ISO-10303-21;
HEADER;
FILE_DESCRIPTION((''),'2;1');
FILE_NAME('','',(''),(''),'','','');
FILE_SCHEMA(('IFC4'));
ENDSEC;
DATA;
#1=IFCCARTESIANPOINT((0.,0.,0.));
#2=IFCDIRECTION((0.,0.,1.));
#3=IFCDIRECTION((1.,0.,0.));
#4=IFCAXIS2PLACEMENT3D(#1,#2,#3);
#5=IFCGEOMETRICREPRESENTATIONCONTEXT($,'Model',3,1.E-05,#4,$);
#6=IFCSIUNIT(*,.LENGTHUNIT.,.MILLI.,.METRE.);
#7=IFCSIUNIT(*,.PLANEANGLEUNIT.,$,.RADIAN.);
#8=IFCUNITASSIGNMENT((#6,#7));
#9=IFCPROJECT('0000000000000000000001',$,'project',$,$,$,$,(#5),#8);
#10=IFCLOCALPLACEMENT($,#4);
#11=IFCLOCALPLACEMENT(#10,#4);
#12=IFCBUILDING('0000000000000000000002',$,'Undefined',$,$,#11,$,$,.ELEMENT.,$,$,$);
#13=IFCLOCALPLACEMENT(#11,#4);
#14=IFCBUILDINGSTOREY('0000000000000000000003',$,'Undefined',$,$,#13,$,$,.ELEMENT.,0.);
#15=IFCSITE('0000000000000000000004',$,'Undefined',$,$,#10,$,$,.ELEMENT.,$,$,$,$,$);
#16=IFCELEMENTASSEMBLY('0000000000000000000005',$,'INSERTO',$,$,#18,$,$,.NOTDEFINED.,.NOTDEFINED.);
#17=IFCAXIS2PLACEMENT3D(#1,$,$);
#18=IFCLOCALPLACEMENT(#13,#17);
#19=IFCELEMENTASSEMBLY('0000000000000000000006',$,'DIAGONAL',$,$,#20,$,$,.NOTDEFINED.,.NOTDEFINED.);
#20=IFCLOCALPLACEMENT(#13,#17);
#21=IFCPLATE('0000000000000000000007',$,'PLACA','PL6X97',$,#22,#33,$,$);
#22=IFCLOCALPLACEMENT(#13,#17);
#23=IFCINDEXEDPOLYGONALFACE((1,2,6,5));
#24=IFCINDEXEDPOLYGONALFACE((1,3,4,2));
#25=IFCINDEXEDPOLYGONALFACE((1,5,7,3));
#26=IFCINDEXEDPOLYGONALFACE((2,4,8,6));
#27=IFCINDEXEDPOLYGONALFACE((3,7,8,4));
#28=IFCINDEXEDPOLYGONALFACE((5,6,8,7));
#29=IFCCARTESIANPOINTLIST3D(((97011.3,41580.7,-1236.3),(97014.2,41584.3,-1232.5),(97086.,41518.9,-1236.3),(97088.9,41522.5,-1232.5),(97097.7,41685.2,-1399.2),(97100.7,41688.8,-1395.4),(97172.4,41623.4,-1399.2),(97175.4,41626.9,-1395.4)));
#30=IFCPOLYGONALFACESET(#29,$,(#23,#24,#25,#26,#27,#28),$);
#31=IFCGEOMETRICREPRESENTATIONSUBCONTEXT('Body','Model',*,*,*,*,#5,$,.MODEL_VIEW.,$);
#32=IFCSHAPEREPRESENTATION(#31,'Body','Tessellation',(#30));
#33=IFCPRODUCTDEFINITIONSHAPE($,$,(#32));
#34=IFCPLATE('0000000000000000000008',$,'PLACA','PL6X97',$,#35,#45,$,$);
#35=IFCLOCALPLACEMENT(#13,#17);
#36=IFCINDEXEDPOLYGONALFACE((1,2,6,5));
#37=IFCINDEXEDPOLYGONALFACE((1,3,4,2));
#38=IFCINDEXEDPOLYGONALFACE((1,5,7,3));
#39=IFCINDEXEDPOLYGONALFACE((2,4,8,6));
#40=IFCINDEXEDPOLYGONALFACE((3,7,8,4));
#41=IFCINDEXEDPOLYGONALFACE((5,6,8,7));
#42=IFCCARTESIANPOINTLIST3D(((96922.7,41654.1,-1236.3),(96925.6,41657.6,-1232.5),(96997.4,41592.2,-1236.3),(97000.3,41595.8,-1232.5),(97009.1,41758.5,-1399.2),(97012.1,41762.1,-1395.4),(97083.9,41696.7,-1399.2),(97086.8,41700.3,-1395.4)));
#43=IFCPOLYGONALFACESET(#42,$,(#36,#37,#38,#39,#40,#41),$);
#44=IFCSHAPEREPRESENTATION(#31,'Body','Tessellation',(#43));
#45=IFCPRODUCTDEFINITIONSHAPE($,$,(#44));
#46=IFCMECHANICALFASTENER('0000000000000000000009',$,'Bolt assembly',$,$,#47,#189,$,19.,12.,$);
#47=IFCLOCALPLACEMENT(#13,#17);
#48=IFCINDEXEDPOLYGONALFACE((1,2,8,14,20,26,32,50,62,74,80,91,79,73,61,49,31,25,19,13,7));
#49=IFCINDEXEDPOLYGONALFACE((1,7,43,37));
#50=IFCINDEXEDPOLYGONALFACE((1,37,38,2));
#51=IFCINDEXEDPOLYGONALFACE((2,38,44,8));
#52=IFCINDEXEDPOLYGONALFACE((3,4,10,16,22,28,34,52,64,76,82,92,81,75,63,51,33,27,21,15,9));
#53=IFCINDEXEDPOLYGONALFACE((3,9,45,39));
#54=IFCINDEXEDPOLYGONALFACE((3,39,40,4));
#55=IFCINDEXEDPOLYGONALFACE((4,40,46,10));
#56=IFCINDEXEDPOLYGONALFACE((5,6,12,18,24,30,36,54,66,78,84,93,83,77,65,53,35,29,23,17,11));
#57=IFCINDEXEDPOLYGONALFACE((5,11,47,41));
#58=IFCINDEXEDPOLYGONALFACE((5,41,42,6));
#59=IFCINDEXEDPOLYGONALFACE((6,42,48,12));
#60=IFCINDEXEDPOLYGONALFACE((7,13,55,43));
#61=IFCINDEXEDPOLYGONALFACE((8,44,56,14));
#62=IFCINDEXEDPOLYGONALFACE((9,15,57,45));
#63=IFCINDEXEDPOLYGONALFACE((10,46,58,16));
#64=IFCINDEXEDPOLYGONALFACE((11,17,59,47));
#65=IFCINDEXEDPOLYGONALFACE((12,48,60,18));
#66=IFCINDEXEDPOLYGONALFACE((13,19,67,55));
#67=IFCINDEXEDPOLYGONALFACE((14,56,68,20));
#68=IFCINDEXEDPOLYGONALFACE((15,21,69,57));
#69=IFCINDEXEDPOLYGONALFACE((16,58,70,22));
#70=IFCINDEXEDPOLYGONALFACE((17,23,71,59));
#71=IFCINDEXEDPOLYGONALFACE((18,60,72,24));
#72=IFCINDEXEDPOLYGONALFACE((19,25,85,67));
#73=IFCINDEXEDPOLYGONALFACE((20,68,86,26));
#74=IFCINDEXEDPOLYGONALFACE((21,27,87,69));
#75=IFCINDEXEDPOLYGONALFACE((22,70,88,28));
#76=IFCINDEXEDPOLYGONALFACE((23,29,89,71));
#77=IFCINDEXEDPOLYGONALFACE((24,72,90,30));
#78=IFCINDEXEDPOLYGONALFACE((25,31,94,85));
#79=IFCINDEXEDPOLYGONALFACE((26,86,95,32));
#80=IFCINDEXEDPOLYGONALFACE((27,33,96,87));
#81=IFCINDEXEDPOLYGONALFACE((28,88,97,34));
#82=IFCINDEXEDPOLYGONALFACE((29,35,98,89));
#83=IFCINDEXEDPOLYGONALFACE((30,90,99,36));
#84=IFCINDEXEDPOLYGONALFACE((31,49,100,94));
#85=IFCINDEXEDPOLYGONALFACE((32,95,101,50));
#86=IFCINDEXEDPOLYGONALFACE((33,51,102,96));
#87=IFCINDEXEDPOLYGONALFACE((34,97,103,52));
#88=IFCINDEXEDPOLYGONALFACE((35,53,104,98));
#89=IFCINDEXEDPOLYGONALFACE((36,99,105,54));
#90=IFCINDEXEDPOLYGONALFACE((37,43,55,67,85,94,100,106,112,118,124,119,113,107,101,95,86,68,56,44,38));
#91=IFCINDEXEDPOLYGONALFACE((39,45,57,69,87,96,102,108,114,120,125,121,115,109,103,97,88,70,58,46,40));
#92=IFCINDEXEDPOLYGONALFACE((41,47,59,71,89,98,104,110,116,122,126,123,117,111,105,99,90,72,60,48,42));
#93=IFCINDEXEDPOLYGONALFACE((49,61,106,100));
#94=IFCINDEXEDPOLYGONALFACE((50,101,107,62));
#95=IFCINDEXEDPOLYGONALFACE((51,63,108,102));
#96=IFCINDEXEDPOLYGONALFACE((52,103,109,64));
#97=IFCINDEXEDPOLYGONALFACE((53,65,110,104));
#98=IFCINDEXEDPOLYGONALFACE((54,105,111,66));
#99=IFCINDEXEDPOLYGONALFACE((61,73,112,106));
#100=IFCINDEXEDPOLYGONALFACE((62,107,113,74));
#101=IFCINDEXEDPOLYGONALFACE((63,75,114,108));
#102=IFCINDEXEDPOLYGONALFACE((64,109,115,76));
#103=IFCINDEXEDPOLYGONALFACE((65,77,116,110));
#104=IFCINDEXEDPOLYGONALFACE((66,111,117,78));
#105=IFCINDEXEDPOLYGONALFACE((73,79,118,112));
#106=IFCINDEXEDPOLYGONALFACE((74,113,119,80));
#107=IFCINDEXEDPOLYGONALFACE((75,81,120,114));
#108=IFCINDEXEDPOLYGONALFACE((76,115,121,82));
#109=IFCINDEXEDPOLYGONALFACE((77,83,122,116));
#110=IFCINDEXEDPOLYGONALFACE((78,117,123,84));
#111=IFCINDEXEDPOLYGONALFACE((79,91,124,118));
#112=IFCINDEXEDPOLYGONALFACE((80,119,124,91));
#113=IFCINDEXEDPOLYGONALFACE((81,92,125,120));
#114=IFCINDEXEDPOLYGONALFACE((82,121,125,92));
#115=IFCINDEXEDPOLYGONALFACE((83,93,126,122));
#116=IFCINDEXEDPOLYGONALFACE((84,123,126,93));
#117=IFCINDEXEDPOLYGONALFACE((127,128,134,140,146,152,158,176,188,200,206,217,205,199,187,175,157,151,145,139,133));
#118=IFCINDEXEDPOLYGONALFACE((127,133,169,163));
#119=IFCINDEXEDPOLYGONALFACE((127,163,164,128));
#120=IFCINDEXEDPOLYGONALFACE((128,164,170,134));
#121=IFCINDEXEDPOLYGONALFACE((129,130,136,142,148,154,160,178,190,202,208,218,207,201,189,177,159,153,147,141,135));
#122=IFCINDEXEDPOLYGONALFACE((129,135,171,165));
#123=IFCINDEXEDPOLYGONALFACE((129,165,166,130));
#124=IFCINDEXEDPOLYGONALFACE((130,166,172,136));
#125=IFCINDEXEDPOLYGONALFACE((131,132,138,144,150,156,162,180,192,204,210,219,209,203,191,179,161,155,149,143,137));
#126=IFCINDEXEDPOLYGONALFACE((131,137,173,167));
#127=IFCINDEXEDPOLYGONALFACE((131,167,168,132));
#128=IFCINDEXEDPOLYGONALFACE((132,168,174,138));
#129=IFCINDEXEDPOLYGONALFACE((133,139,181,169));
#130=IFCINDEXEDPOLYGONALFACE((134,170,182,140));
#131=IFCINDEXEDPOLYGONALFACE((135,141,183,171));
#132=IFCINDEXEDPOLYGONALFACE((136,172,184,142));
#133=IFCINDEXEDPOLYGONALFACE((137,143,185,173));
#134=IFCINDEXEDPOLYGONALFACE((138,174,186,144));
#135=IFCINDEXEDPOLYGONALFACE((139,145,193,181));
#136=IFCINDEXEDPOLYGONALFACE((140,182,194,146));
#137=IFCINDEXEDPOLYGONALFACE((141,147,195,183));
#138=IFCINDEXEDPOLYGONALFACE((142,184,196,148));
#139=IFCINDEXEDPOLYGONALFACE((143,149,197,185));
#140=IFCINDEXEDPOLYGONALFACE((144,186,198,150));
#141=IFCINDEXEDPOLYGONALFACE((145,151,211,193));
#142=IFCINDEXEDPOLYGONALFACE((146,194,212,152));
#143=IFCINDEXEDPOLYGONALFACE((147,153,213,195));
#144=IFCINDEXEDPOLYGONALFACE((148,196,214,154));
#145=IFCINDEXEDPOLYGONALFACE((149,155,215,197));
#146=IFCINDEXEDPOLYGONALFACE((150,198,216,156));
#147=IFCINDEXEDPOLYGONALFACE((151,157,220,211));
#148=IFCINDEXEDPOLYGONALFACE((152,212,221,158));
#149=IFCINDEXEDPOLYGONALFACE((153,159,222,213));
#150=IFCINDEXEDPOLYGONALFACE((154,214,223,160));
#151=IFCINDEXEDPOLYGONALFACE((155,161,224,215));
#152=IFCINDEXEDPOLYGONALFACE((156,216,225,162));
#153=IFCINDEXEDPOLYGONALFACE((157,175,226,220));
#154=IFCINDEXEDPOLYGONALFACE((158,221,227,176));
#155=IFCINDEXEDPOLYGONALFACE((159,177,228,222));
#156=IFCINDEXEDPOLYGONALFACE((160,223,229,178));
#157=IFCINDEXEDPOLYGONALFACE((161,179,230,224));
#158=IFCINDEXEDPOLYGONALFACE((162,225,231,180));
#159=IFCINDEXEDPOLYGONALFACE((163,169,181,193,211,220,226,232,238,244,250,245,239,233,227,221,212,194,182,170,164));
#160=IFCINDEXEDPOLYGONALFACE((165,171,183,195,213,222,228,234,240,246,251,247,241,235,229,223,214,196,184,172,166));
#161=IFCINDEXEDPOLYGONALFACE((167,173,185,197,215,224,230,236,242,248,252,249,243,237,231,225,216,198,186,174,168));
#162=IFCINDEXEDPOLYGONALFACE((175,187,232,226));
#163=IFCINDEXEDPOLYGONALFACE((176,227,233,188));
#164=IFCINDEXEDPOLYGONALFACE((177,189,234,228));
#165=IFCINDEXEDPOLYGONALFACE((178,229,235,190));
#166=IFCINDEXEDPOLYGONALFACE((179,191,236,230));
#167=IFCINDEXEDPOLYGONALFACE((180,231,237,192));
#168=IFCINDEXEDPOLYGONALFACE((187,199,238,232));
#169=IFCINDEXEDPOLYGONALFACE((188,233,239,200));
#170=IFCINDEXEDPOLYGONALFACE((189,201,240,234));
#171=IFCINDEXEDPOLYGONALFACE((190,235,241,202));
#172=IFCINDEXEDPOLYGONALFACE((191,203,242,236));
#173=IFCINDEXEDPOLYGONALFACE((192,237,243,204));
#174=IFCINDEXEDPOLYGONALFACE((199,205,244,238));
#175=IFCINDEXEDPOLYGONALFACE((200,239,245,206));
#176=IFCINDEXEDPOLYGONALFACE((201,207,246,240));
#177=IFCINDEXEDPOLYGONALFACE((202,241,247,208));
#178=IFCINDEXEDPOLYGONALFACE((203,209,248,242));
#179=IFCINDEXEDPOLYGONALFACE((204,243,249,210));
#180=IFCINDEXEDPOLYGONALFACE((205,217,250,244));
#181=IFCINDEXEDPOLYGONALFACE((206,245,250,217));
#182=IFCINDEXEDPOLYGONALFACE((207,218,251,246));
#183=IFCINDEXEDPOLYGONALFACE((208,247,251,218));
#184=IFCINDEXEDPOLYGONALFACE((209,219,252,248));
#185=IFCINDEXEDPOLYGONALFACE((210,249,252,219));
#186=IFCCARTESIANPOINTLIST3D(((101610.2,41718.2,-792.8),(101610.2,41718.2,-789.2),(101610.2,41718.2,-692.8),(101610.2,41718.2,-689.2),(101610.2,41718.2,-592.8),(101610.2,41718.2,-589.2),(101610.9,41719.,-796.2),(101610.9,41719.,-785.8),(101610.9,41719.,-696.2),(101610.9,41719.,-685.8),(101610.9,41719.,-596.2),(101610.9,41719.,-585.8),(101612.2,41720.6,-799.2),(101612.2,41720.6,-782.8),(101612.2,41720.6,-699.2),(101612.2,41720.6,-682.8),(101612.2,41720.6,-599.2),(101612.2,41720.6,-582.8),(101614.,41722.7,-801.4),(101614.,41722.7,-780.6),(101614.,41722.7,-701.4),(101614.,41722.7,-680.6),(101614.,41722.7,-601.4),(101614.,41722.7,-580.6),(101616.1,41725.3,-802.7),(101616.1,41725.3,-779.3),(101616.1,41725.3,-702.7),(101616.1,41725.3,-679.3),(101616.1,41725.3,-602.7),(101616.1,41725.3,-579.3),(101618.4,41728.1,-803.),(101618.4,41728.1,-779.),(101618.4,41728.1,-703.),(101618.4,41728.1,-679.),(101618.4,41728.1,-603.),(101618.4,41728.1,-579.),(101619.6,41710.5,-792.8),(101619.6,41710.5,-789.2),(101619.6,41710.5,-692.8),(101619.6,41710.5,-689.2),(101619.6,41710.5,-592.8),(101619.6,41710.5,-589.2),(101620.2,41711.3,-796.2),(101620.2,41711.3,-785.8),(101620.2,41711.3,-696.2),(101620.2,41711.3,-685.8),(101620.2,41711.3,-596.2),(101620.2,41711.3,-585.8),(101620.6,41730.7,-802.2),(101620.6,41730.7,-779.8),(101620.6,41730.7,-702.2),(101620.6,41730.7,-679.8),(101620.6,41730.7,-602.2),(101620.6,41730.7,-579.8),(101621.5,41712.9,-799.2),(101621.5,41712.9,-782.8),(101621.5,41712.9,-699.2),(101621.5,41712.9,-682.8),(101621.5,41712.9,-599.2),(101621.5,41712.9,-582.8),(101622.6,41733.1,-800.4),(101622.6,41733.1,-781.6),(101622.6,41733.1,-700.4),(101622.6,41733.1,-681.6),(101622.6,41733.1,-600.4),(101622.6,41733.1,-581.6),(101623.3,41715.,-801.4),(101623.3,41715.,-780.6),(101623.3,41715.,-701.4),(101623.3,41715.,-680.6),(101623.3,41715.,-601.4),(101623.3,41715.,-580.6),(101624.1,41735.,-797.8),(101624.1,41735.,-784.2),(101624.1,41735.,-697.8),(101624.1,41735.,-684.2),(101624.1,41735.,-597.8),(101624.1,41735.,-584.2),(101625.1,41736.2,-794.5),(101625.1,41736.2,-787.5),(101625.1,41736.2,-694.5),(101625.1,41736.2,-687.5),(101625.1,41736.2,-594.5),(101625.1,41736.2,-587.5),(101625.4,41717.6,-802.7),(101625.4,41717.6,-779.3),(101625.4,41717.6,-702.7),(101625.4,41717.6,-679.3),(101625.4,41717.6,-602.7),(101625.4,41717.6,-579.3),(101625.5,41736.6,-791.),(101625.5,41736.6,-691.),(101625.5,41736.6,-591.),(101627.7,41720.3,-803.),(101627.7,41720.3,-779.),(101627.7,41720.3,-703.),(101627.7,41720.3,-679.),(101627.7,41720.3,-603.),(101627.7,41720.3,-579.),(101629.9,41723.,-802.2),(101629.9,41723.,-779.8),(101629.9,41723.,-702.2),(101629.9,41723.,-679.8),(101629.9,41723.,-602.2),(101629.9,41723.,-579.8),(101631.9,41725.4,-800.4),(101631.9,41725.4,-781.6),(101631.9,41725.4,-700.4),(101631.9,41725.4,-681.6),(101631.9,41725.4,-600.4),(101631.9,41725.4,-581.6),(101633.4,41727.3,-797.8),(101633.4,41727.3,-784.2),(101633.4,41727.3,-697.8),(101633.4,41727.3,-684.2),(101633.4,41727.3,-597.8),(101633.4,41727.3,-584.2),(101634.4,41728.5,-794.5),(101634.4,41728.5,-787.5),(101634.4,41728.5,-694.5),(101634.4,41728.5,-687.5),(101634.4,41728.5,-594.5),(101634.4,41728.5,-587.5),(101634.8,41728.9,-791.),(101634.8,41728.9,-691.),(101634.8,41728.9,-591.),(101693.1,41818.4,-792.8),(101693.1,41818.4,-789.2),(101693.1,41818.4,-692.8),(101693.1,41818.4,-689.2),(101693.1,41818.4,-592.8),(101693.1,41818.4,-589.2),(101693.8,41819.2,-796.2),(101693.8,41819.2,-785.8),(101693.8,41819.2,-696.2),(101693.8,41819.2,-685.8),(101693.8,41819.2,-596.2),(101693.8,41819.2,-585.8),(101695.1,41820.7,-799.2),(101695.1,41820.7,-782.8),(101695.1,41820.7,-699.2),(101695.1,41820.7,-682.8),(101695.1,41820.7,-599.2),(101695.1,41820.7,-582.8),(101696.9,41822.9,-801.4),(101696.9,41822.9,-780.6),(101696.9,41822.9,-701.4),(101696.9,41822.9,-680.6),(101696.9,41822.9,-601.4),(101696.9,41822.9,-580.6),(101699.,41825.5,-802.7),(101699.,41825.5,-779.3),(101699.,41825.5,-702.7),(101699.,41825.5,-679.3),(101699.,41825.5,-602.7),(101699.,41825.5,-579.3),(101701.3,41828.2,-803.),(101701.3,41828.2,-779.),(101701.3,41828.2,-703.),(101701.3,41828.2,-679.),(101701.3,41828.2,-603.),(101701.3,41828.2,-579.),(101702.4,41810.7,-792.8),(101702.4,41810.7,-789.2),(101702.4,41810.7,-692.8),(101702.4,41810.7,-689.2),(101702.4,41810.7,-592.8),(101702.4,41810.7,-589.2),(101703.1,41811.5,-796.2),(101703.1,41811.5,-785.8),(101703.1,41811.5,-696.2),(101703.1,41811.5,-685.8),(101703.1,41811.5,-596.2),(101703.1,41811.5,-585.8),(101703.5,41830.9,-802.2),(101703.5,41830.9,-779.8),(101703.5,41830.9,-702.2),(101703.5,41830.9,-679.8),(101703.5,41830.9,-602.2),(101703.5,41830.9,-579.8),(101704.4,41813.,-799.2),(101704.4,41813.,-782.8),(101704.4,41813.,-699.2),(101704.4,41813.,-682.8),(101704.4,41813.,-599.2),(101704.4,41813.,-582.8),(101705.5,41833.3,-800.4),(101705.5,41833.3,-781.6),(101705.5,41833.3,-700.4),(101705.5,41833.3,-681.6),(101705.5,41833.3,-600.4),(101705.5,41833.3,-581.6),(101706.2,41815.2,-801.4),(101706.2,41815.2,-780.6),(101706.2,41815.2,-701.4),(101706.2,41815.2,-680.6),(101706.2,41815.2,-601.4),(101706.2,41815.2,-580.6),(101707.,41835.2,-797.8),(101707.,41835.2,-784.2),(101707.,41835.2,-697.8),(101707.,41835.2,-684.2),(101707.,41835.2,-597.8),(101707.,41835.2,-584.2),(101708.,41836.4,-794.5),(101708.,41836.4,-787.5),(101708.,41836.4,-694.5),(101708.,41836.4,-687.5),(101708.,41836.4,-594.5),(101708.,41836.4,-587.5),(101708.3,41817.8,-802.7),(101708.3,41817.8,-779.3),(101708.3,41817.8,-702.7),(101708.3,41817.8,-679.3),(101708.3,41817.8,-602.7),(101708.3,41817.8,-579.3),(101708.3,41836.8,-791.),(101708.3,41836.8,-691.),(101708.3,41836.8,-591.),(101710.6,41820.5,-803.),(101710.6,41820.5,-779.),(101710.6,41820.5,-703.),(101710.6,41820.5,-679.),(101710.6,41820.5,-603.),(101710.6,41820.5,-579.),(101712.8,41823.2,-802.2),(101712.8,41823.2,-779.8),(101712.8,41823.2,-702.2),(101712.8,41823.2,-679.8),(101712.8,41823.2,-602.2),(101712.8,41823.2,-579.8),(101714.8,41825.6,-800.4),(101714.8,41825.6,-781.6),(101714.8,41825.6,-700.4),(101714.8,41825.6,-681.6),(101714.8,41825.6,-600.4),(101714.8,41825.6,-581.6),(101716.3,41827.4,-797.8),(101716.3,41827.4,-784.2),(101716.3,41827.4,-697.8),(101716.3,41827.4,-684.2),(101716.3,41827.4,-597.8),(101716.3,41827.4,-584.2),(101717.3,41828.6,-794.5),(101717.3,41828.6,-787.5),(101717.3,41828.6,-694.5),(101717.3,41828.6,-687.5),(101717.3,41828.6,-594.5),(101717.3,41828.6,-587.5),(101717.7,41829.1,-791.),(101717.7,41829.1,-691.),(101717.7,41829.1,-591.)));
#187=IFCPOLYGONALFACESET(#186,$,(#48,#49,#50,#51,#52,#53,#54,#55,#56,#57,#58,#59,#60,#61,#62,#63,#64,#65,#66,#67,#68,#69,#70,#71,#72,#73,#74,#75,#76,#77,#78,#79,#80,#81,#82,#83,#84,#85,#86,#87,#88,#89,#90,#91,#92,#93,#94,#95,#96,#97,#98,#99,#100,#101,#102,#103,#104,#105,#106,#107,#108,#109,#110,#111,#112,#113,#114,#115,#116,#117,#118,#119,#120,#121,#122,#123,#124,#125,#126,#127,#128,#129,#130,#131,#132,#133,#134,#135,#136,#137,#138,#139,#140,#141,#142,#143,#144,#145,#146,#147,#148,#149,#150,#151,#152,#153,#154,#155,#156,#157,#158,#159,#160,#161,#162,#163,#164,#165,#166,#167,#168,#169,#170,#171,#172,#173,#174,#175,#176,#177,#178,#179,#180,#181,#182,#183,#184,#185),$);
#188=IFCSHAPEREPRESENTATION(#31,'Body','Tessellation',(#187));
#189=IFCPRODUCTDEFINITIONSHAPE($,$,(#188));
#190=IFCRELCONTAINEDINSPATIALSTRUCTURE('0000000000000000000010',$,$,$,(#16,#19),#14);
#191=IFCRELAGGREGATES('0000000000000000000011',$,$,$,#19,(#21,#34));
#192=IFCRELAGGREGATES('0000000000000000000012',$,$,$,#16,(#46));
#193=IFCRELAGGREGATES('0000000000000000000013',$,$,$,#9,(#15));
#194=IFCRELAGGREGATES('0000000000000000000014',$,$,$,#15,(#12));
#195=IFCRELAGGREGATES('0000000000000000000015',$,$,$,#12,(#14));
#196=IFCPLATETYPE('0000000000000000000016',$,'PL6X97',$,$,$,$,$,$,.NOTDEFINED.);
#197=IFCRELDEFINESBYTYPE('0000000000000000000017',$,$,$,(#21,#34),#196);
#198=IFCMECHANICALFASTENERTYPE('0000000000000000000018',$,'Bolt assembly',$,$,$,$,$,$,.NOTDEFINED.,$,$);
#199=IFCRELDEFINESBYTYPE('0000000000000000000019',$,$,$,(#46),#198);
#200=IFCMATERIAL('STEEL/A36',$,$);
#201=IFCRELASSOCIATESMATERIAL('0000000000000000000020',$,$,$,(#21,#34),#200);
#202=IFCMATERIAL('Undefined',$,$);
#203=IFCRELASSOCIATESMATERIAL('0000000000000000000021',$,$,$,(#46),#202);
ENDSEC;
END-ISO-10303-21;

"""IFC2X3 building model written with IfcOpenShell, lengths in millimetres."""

from ifc_helpers import new_model, si_unit, frame, origin_with_axes, origin_2d_with_axis, place, context, subcontext, project, spatial, polyline, circle, outline, extrude, source, transform, mapped, material, type_object, element, aggregate, save


model = new_model("IFC2X3")

# Units and contexts
model_context = context("Model", 3, precision=1e-05, world=origin_with_axes())
body_context = subcontext(model_context, "Body", "Model", "MODEL_VIEW")
ifc_project = project(units=[si_unit("LENGTHUNIT", "METRE", prefix="MILLI"), si_unit("PLANEANGLEUNIT", "RADIAN")], contexts=[model_context])

# Site, building, storey
site_placement = place(None, origin_with_axes())
site = spatial("IfcSite", under=ifc_project, at=site_placement, Name="Undefined", CompositionType="ELEMENT")
building_placement = place(site_placement, origin_with_axes())
building = spatial("IfcBuilding", under=site, at=building_placement, Name="Undefined", CompositionType="ELEMENT")
storey_placement = place(building_placement, origin_with_axes())
storey = spatial("IfcBuildingStorey", under=building, at=storey_placement, Name="Undefined", CompositionType="ELEMENT", Elevation=0.0)

# Element assembly
assembly_1_placement = place(storey_placement, origin_with_axes())
assembly_1 = element("IfcElementAssembly", 1, at=assembly_1_placement, inside=storey, Name="INSERTO", AssemblyPlace="NOTDEFINED", PredefinedType="NOTDEFINED")
ifc_material_1 = material(Name="STEEL/A36")

# Element assembly, plates
assembly_2_placement = place(storey_placement, origin_with_axes())
assembly_2 = element("IfcElementAssembly", 2, at=assembly_2_placement, inside=storey, Name="DIAGONAL", AssemblyPlace="NOTDEFINED", PredefinedType="NOTDEFINED")
plate_type_1 = type_object("IfcPlateType", Name="PL6X97", PredefinedType="NOTDEFINED")
plate_1_placement = place(assembly_2_placement, frame((97087.5, 41520.7, -1234.4), z_axis=(-0.490051, -0.592157, -0.639687), x_axis=(-0.770401, 0.63756, 0.0)))
plate_1 = element("IfcPlate", 3, at=plate_1_placement, type_object=plate_type_1, material=ifc_material_1, Name="PLACA", Description="PL6X97", context=body_context, shape_type="SweptSolid", body=[
    extrude(outline(polyline([(0.0, 0.0), (97.0, 0.0), (97.0, 212.0), (0.0, 212.0), (0.0, 0.0)])), frame((0.0, 0.0, -3.0), z_axis=(0.0, 0.0, 1.0), x_axis=(1.0, 0.0, 0.0)), (0.0, 0.0, 1.0), 6.0),
])
plate_2_placement = place(assembly_2_placement, frame((96998.9, 41594.0, -1234.4), z_axis=(-0.490051, -0.592157, -0.639687), x_axis=(-0.770401, 0.63756, 0.0)))
plate_2 = element("IfcPlate", 4, at=plate_2_placement, type_object=plate_type_1, material=ifc_material_1, Name="PLACA", Description="PL6X97", context=body_context, shape_type="SweptSolid", body=[
    extrude(outline(polyline([(0.0, 0.0), (97.0, 0.0), (97.0, 212.0), (0.0, 212.0), (0.0, 0.0)])), frame((0.0, 0.0, -3.0), z_axis=(0.0, 0.0, 1.0), x_axis=(1.0, 0.0, 0.0)), (0.0, 0.0, 1.0), 6.0),
])
aggregate(assembly_2, [plate_1, plate_2])

# Mechanical fastener
ifc_material_2 = material(Name="Undefined")
mechanical_fastener_type = type_object("IfcMechanicalFastenerType", Name="Bolt assembly")
shared_shape_1 = source(origin_with_axes(), body_context, "Body", "SweptSolid", [
    extrude(circle(Radius=12.0, at=origin_2d_with_axis()), frame((0.0, 0.0, 0.0), z_axis=(0.0, 1.0, 0.0), x_axis=(1.0, 0.0, 0.0)), (0.0, 0.0, 1.0), 12.1),
])
mechanical_fastener_1_placement = place(assembly_1_placement, frame((101627.1, 41719.7, -691.0), z_axis=(0.000001, 0.000001, 1.0), x_axis=(0.637563, 0.770399, -0.000002)))
mechanical_fastener_1 = element("IfcMechanicalFastener", 5, at=mechanical_fastener_1_placement, type_object=mechanical_fastener_type, material=ifc_material_2, Name="Bolt assembly", NominalDiameter=19.0, NominalLength=12.0, context=body_context, shape_type="MappedRepresentation", body=[
    mapped(shared_shape_1, transform((0.0, 0.0, -100.0))),
    mapped(shared_shape_1, transform((130.0, 0.0, -100.0))),
    mapped(shared_shape_1, transform((0.0, 0.0, 0.0))),
    mapped(shared_shape_1, transform((130.0, 0.0, 0.0))),
    mapped(shared_shape_1, transform((0.0, 0.0, 100.0))),
    mapped(shared_shape_1, transform((130.0, 0.0, 100.0))),
])
aggregate(assembly_1, [mechanical_fastener_1])

save(model, "model.ifc")
